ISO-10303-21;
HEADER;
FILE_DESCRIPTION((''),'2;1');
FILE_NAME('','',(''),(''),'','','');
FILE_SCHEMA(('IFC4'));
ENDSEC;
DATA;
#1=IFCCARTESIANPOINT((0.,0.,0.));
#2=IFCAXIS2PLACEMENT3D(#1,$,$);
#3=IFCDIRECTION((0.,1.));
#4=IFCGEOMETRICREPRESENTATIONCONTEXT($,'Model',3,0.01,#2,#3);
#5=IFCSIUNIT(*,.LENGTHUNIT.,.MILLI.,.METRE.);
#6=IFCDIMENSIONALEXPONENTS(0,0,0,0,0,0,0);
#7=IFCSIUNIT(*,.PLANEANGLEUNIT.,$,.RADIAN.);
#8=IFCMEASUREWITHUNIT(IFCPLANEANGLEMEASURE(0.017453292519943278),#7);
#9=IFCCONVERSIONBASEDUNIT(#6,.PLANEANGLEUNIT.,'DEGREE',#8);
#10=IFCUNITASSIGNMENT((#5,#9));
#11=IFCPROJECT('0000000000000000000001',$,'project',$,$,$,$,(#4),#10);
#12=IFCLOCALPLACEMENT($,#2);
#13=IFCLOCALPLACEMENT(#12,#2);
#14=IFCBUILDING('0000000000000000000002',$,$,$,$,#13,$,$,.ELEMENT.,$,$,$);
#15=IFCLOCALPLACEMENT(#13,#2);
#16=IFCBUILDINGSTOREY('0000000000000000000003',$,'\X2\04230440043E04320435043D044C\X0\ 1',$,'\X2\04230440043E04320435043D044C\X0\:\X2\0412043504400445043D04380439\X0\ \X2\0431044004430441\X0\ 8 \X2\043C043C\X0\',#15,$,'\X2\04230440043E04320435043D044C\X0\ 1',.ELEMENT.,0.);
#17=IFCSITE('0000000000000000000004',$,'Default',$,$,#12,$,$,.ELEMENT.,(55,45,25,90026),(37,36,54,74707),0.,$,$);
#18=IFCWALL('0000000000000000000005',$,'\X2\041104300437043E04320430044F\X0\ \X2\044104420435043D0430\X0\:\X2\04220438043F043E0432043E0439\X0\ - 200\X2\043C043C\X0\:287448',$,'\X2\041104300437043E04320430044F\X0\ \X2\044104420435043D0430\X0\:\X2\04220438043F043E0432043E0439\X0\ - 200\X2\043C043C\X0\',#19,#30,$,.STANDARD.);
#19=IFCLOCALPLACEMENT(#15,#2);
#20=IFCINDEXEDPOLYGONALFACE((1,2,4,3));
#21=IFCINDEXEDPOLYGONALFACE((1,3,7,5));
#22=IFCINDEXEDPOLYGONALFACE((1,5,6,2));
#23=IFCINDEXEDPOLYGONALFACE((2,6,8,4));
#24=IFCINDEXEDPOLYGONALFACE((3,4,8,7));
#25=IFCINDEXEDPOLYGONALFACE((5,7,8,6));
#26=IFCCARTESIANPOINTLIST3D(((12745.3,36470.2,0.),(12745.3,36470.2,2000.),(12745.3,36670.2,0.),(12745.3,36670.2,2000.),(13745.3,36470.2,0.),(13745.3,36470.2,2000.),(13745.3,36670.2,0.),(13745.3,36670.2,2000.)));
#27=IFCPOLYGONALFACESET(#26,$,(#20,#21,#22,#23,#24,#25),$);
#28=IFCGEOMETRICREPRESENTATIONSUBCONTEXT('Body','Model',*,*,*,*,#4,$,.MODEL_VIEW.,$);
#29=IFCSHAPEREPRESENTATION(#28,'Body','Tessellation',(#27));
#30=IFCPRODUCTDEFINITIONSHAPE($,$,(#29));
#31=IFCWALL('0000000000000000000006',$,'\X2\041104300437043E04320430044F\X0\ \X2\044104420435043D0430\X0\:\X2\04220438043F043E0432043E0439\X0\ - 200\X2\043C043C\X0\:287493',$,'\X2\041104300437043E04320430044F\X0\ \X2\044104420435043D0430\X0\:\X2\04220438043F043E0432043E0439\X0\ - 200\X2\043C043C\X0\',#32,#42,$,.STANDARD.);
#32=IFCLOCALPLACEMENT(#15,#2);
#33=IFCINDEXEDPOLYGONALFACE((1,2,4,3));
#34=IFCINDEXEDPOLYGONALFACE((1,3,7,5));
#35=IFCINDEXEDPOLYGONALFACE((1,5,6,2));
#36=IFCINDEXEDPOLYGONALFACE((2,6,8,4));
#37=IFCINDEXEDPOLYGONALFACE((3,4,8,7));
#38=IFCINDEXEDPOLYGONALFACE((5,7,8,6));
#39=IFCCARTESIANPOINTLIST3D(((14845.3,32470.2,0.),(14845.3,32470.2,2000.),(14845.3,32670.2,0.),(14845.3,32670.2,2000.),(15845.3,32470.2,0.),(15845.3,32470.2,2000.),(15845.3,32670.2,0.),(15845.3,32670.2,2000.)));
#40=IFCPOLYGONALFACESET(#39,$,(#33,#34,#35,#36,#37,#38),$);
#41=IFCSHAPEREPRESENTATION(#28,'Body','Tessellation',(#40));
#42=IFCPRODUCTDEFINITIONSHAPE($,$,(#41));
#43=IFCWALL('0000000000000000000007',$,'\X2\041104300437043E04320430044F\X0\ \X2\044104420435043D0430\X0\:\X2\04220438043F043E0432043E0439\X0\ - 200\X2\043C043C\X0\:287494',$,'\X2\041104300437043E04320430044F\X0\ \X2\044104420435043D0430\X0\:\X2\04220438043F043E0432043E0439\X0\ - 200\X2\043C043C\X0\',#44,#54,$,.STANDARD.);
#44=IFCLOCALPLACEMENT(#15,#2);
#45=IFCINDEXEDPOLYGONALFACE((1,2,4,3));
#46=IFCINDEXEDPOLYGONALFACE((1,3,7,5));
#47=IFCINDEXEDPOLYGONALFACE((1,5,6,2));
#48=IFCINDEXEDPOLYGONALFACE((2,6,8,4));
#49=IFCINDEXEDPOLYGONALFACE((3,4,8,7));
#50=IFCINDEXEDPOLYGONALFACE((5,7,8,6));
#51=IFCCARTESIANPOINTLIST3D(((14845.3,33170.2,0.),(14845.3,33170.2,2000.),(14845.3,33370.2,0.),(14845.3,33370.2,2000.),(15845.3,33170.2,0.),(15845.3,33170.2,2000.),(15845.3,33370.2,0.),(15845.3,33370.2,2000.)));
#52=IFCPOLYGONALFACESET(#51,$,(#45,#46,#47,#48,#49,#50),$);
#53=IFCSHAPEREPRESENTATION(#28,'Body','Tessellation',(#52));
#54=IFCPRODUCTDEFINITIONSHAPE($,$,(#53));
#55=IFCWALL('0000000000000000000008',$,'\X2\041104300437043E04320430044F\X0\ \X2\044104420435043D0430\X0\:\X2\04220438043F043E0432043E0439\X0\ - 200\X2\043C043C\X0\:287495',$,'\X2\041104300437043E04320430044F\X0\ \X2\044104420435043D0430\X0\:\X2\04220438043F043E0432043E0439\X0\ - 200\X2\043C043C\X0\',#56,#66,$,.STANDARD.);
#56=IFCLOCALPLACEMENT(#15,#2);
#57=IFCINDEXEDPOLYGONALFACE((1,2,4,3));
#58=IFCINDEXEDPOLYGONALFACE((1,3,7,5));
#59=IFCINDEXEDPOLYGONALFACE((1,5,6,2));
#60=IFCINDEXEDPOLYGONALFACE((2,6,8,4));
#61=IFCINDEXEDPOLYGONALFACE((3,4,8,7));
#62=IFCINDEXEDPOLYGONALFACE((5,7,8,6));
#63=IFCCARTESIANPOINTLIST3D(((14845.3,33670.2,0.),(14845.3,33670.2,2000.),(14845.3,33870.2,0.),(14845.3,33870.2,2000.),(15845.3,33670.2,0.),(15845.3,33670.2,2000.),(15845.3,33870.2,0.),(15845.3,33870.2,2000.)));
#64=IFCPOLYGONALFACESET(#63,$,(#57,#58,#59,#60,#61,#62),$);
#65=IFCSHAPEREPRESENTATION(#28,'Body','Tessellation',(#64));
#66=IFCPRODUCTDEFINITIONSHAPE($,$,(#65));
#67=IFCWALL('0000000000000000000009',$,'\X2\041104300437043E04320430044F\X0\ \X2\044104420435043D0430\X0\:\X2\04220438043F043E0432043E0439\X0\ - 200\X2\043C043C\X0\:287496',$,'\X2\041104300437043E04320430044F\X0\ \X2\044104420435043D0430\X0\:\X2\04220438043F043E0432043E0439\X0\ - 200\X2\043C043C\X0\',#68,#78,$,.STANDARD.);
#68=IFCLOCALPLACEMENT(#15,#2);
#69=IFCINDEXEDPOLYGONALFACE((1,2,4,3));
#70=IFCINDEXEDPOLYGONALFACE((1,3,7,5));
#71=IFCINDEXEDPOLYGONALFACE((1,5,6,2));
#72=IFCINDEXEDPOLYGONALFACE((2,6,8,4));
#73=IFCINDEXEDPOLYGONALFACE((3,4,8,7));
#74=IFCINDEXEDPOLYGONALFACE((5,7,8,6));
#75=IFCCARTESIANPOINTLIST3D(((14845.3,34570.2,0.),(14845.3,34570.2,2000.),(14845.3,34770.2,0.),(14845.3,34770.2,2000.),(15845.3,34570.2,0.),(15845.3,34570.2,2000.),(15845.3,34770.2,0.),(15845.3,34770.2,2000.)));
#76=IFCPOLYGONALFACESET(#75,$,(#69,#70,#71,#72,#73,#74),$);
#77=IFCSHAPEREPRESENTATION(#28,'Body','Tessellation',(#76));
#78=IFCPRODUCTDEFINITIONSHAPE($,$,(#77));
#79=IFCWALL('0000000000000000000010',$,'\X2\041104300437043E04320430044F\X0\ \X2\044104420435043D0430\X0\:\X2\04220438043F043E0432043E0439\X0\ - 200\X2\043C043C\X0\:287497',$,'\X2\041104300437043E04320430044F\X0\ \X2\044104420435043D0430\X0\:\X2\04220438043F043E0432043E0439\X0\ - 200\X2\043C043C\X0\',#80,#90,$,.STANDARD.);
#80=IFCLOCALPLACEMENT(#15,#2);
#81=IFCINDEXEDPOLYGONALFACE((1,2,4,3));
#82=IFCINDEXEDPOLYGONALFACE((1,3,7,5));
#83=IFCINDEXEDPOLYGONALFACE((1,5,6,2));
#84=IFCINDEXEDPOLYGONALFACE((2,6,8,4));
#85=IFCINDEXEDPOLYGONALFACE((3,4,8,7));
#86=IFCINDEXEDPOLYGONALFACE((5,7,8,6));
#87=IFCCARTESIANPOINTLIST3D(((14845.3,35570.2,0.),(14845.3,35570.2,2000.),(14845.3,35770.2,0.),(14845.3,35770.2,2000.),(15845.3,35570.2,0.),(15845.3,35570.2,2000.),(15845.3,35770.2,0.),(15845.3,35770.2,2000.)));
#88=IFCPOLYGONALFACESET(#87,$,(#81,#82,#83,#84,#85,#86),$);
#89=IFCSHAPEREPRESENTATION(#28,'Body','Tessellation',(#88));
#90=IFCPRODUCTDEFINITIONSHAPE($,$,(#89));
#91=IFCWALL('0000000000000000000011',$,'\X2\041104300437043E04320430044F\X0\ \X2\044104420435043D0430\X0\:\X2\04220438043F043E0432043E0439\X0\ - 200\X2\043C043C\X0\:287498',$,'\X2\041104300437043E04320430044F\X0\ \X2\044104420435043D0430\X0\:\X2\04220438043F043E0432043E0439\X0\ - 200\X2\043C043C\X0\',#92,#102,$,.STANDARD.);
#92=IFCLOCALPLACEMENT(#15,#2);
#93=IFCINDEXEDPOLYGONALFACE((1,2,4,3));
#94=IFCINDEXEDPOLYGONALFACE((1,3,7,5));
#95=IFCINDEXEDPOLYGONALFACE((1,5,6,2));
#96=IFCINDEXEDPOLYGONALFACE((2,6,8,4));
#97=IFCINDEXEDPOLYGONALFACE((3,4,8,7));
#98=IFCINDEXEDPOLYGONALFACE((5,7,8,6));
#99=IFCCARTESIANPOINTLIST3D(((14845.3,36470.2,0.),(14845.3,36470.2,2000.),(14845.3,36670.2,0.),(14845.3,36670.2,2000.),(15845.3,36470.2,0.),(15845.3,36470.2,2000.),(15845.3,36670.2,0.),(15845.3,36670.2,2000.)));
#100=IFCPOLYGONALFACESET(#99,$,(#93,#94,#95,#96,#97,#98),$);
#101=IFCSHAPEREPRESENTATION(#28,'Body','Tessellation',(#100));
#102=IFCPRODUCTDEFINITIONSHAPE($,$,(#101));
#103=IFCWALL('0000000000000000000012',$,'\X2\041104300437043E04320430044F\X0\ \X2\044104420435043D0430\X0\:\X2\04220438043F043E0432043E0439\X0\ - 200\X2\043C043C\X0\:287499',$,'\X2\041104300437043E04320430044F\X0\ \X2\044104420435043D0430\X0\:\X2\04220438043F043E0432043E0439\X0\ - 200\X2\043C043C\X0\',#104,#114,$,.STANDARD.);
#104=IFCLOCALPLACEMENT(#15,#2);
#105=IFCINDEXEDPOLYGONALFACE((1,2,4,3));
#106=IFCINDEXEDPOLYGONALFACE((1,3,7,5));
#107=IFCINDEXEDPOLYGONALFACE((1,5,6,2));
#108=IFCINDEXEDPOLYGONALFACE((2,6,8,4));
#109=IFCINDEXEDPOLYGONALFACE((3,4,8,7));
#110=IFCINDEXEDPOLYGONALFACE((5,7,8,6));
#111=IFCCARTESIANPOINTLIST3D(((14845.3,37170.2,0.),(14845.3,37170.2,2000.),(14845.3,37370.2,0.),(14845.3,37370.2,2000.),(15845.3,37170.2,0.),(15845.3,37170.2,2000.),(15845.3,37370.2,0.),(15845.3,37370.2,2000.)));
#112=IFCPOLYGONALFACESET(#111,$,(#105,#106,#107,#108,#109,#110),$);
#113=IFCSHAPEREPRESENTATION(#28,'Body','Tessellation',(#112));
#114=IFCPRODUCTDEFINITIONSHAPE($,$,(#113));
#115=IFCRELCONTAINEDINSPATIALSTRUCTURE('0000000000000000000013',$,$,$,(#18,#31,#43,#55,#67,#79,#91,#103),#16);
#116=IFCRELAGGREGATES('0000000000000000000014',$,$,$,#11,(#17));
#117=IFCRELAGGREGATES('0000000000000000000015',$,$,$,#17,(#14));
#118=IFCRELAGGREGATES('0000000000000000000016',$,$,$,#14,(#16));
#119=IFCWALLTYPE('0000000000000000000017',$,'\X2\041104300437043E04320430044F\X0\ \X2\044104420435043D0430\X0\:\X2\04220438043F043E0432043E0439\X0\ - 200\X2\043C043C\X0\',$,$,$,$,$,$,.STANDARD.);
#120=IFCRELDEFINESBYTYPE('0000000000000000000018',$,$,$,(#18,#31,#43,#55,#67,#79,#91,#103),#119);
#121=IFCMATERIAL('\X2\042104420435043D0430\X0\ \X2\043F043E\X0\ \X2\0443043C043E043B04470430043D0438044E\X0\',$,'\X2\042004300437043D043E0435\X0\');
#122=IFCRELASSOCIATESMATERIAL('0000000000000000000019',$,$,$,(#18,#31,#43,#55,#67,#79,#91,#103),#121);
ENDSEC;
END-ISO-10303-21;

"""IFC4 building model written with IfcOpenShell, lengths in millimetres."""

from ifc_helpers import new_model, entity, si_unit, converted_unit, direction, frame, origin, place, context, subcontext, project, spatial, indexed_curve, outline, extrude, material, type_object, element, save


model = new_model("IFC4")

# Units and contexts
model_context = context("Model", 3, precision=0.01, world=origin(), true_north=direction((0.0, 1.0)))
body_context = subcontext(model_context, "Body", "Model", "MODEL_VIEW")
ifc_project = project(units=[si_unit("LENGTHUNIT", "METRE", prefix="MILLI"), converted_unit("PLANEANGLEUNIT", "DEGREE", entity("IfcPlaneAngleMeasure", 0.017453292519943278), si_unit("PLANEANGLEUNIT", "RADIAN"), dimensions=[0, 0, 0, 0, 0, 0, 0])], contexts=[model_context])

# Site, building, storey
site_placement = place(None, origin())
site = spatial("IfcSite", under=ifc_project, at=site_placement, Name="Default", CompositionType="ELEMENT", RefLatitude=(55, 45, 25, 90026), RefLongitude=(37, 36, 54, 74707), RefElevation=0.0)
building_placement = place(site_placement, origin())
building = spatial("IfcBuilding", under=site, at=building_placement, CompositionType="ELEMENT")
storey_placement = place(building_placement, origin())
storey = spatial("IfcBuildingStorey", under=building, at=storey_placement, Name="Уровень 1", ObjectType="Уровень:Верхний брус 8 мм", LongName="Уровень 1", CompositionType="ELEMENT", Elevation=0.0)

# Walls
ifc_material = material(Name="Стена по умолчанию", Category="Разное")
wall_type = type_object("IfcWallType", Name="Базовая стена:Типовой - 200мм", PredefinedType="STANDARD")
wall_1_placement = place(storey_placement, frame((12745.3, 36570.2, 0.0)))
element("IfcWall", 1, at=wall_1_placement, inside=storey, type_object=wall_type, material=ifc_material, Name="Базовая стена:Типовой - 200мм:287448", ObjectType="Базовая стена:Типовой - 200мм", PredefinedType="STANDARD", context=body_context, shape_type="SweptSolid", body=[
    extrude(outline(indexed_curve([(1000.0, 100.0), (0.0, 100.0), (0.0, -100.0), (1000.0, -100.0), (1000.0, 100.0)], self_intersect=False)), origin(), (0.0, 0.0, 1.0), 2000.0),
])
wall_2_placement = place(storey_placement, frame((14845.3, 32570.2, 0.0)))
element("IfcWall", 2, at=wall_2_placement, inside=storey, type_object=wall_type, material=ifc_material, Name="Базовая стена:Типовой - 200мм:287493", ObjectType="Базовая стена:Типовой - 200мм", PredefinedType="STANDARD", context=body_context, shape_type="SweptSolid", body=[
    extrude(outline(indexed_curve([(1000.0, 100.0), (0.0, 100.0), (0.0, -100.0), (1000.0, -100.0), (1000.0, 100.0)], self_intersect=False)), origin(), (0.0, 0.0, 1.0), 2000.0),
])
wall_3_placement = place(storey_placement, frame((14845.3, 33270.2, 0.0)))
element("IfcWall", 3, at=wall_3_placement, inside=storey, type_object=wall_type, material=ifc_material, Name="Базовая стена:Типовой - 200мм:287494", ObjectType="Базовая стена:Типовой - 200мм", PredefinedType="STANDARD", context=body_context, shape_type="SweptSolid", body=[
    extrude(outline(indexed_curve([(1000.0, 100.0), (0.0, 100.0), (0.0, -100.0), (1000.0, -100.0), (1000.0, 100.0)], self_intersect=False)), origin(), (0.0, 0.0, 1.0), 2000.0),
])
wall_4_placement = place(storey_placement, frame((14845.3, 33770.2, 0.0)))
element("IfcWall", 4, at=wall_4_placement, inside=storey, type_object=wall_type, material=ifc_material, Name="Базовая стена:Типовой - 200мм:287495", ObjectType="Базовая стена:Типовой - 200мм", PredefinedType="STANDARD", context=body_context, shape_type="SweptSolid", body=[
    extrude(outline(indexed_curve([(1000.0, 100.0), (0.0, 100.0), (0.0, -100.0), (1000.0, -100.0), (1000.0, 100.0)], self_intersect=False)), origin(), (0.0, 0.0, 1.0), 2000.0),
])
wall_5_placement = place(storey_placement, frame((14845.3, 34670.2, 0.0)))
element("IfcWall", 5, at=wall_5_placement, inside=storey, type_object=wall_type, material=ifc_material, Name="Базовая стена:Типовой - 200мм:287496", ObjectType="Базовая стена:Типовой - 200мм", PredefinedType="STANDARD", context=body_context, shape_type="SweptSolid", body=[
    extrude(outline(indexed_curve([(1000.0, 100.0), (0.0, 100.0), (0.0, -100.0), (1000.0, -100.0), (1000.0, 100.0)], self_intersect=False)), origin(), (0.0, 0.0, 1.0), 2000.0),
])
wall_6_placement = place(storey_placement, frame((14845.3, 35670.2, 0.0)))
element("IfcWall", 6, at=wall_6_placement, inside=storey, type_object=wall_type, material=ifc_material, Name="Базовая стена:Типовой - 200мм:287497", ObjectType="Базовая стена:Типовой - 200мм", PredefinedType="STANDARD", context=body_context, shape_type="SweptSolid", body=[
    extrude(outline(indexed_curve([(1000.0, 100.0), (0.0, 100.0), (0.0, -100.0), (1000.0, -100.0), (1000.0, 100.0)], self_intersect=False)), origin(), (0.0, 0.0, 1.0), 2000.0),
])
wall_7_placement = place(storey_placement, frame((14845.3, 36570.2, 0.0)))
element("IfcWall", 7, at=wall_7_placement, inside=storey, type_object=wall_type, material=ifc_material, Name="Базовая стена:Типовой - 200мм:287498", ObjectType="Базовая стена:Типовой - 200мм", PredefinedType="STANDARD", context=body_context, shape_type="SweptSolid", body=[
    extrude(outline(indexed_curve([(1000.0, 100.0), (0.0, 100.0), (0.0, -100.0), (1000.0, -100.0), (1000.0, 100.0)], self_intersect=False)), origin(), (0.0, 0.0, 1.0), 2000.0),
])
wall_8_placement = place(storey_placement, frame((14845.3, 37270.2, 0.0)))
element("IfcWall", 8, at=wall_8_placement, inside=storey, type_object=wall_type, material=ifc_material, Name="Базовая стена:Типовой - 200мм:287499", ObjectType="Базовая стена:Типовой - 200мм", PredefinedType="STANDARD", context=body_context, shape_type="SweptSolid", body=[
    extrude(outline(indexed_curve([(1000.0, 100.0), (0.0, 100.0), (0.0, -100.0), (1000.0, -100.0), (1000.0, 100.0)], self_intersect=False)), origin(), (0.0, 0.0, 1.0), 2000.0),
])

save(model, "model.ifc")
